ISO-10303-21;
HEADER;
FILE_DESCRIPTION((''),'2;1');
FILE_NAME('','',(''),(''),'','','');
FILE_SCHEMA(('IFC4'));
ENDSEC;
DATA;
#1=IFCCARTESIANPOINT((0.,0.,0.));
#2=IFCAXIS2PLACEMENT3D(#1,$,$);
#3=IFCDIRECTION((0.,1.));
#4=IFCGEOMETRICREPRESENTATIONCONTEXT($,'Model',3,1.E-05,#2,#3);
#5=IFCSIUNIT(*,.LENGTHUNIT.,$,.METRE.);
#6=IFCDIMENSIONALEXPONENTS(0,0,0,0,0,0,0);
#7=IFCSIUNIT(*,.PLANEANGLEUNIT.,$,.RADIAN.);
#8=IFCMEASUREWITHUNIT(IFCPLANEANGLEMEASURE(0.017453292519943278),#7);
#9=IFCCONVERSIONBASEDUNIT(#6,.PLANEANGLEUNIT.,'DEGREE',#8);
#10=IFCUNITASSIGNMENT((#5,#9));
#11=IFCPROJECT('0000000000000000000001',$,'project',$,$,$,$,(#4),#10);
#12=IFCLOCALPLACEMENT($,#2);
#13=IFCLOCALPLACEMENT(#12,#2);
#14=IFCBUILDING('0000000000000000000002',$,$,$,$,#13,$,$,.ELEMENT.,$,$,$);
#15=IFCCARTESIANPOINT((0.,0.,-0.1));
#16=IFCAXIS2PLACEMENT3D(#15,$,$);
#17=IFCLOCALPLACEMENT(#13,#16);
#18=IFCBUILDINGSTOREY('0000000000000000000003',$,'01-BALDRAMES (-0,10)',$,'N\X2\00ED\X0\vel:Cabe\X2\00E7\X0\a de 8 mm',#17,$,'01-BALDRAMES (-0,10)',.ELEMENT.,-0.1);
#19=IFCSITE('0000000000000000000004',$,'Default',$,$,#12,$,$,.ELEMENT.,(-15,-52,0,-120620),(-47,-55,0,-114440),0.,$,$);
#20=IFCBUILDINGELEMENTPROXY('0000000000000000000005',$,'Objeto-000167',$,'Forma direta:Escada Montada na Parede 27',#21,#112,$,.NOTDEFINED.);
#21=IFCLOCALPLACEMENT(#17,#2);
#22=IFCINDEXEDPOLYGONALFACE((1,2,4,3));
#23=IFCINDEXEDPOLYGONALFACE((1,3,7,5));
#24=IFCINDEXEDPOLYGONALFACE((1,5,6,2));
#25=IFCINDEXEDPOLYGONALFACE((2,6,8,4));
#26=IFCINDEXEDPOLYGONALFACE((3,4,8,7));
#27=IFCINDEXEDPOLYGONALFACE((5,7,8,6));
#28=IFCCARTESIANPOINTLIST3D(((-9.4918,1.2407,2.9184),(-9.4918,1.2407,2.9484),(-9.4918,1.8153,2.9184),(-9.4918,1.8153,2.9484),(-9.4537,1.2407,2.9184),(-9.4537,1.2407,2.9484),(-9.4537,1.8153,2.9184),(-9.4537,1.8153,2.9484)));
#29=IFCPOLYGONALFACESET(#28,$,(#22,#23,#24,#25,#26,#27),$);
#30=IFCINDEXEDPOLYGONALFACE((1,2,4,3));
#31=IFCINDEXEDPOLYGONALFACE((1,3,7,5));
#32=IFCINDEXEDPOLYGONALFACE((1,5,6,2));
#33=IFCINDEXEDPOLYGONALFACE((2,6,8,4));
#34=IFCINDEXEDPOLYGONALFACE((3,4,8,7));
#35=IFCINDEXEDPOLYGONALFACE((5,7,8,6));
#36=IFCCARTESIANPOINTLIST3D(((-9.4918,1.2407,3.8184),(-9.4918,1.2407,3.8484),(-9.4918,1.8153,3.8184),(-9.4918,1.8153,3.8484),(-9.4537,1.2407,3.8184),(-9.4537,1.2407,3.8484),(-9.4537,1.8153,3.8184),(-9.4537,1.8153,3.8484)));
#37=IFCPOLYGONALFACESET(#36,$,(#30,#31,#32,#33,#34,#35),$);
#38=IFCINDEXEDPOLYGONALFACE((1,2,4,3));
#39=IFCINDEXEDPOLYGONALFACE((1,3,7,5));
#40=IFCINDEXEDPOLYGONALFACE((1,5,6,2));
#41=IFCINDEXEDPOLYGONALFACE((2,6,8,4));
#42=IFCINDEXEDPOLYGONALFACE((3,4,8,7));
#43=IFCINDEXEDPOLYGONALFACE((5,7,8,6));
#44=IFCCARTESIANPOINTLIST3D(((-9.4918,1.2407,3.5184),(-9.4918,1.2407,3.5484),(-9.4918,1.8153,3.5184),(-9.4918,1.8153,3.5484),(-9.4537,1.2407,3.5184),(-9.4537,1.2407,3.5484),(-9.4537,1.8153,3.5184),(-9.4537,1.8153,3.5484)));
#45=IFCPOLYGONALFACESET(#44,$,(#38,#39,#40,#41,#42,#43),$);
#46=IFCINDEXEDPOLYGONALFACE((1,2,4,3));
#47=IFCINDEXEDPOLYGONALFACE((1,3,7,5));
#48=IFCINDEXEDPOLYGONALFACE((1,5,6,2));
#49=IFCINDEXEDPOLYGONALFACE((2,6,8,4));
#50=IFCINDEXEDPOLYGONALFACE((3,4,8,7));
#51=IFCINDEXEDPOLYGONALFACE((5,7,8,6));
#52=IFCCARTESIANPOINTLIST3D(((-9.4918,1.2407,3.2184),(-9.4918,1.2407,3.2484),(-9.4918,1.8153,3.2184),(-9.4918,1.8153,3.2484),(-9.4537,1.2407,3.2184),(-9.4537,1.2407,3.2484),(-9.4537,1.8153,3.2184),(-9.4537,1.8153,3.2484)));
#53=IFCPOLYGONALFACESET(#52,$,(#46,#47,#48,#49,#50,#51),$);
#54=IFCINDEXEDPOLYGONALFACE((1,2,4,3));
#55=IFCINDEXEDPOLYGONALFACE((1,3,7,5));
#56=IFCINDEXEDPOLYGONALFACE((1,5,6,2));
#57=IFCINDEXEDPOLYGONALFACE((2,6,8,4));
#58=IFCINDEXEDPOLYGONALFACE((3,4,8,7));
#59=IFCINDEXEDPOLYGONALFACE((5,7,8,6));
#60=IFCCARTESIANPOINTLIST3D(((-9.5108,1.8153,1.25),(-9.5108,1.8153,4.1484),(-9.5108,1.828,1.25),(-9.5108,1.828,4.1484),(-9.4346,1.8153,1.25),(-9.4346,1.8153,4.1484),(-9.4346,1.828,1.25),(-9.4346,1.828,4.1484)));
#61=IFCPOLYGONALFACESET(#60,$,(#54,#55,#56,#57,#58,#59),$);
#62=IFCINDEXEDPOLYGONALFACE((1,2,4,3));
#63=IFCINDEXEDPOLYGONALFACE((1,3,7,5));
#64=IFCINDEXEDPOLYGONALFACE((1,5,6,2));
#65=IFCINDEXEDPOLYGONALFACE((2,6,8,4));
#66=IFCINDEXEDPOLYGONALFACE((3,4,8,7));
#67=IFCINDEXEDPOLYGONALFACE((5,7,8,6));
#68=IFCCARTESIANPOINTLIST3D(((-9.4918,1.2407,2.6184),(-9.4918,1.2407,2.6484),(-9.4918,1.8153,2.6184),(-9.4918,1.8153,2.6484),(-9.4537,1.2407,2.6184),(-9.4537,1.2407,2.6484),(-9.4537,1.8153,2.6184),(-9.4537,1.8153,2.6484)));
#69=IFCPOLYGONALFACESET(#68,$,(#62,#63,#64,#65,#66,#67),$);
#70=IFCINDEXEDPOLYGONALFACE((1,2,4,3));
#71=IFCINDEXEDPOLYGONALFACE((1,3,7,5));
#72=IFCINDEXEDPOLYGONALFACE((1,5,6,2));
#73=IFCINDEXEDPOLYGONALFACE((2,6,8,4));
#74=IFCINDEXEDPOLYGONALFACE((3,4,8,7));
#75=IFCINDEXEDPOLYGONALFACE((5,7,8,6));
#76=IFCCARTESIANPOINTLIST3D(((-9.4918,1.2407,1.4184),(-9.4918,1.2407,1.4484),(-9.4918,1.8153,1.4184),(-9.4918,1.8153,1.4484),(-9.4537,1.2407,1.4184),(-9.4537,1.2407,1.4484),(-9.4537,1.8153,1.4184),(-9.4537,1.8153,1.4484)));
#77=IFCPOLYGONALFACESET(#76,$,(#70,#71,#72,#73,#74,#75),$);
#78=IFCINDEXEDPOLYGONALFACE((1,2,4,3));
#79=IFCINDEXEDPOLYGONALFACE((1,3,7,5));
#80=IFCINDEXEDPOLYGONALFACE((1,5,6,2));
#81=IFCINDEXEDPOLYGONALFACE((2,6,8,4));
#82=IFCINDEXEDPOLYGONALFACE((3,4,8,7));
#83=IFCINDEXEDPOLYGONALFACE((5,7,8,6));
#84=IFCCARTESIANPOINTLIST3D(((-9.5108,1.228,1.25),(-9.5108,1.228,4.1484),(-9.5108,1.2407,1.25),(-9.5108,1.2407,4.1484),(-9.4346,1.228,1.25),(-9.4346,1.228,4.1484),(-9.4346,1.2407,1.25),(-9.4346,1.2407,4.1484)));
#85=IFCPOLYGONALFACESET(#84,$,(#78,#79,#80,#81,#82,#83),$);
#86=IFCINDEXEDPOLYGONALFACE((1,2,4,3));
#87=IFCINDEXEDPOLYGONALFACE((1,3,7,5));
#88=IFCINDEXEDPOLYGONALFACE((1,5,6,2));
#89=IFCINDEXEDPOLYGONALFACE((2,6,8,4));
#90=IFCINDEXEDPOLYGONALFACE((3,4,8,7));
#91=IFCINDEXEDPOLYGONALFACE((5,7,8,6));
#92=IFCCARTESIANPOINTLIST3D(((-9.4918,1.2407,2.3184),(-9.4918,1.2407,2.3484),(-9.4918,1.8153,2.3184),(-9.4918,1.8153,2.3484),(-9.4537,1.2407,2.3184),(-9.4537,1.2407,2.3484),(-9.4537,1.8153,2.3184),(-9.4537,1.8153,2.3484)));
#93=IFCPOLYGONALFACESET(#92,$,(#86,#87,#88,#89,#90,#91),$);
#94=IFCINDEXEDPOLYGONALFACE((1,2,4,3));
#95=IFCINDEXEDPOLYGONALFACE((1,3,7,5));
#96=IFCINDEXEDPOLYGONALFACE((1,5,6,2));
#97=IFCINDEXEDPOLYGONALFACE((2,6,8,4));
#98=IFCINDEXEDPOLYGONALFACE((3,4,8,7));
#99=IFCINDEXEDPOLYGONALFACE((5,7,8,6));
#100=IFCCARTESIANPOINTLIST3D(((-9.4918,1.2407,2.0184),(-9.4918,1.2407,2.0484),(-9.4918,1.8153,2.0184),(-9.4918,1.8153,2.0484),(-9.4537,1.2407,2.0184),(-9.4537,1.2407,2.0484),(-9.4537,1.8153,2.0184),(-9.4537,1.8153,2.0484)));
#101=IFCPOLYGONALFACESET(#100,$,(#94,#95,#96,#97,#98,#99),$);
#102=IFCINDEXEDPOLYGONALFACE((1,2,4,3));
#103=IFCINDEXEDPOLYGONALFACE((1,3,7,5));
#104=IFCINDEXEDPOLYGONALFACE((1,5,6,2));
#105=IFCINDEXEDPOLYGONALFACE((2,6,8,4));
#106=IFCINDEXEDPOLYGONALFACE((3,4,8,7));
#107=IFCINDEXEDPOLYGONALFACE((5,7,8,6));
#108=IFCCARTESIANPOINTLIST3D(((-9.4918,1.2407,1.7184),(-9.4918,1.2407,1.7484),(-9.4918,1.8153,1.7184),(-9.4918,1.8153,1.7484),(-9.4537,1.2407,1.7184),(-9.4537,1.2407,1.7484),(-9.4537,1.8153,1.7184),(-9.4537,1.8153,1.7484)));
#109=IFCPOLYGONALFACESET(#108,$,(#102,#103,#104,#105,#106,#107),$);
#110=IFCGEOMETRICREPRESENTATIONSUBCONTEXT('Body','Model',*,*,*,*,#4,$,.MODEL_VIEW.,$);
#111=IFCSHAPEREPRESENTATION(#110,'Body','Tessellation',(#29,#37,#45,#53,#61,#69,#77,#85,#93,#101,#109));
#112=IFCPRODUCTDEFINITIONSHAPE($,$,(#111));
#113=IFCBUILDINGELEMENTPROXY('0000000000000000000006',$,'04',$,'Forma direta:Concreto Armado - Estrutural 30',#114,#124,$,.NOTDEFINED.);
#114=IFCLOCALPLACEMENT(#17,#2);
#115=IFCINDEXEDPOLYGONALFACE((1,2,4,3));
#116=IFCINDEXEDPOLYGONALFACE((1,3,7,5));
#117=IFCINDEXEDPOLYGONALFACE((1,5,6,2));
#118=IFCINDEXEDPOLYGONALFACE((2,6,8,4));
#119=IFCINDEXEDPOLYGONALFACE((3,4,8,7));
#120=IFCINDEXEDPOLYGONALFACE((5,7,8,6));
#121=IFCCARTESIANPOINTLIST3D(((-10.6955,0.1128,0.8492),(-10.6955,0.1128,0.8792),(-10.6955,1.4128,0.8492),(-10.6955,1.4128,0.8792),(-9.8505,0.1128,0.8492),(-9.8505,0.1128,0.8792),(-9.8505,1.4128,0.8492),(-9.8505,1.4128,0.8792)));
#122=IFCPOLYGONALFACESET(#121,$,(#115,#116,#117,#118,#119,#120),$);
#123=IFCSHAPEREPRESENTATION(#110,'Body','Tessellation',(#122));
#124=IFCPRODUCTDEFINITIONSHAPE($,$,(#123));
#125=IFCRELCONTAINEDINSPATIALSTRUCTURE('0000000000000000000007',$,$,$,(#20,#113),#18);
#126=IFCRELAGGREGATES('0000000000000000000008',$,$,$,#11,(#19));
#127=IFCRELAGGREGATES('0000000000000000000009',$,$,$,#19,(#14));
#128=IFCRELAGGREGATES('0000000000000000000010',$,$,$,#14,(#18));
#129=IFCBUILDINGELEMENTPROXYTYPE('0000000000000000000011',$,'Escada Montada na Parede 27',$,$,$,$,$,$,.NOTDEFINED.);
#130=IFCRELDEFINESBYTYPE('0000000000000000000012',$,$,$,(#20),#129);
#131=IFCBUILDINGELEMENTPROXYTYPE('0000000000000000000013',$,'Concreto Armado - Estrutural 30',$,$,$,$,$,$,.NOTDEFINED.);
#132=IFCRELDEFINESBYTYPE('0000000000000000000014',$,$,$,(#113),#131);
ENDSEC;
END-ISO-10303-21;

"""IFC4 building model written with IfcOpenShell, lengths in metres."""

from ifc_helpers import new_model, entity, si_unit, converted_unit, direction, frame, origin, place, context, subcontext, project, spatial, indexed_curve, outline, extrude, type_object, element, save


model = new_model("IFC4")

# Units and contexts
model_context = context("Model", 3, precision=1e-05, world=origin(), true_north=direction((0.0, 1.0)))
body_context = subcontext(model_context, "Body", "Model", "MODEL_VIEW")
ifc_project = project(units=[si_unit("LENGTHUNIT", "METRE"), converted_unit("PLANEANGLEUNIT", "DEGREE", entity("IfcPlaneAngleMeasure", 0.017453292519943278), si_unit("PLANEANGLEUNIT", "RADIAN"), dimensions=[0, 0, 0, 0, 0, 0, 0])], contexts=[model_context])

# Site, building, storey
site_placement = place(None, origin())
site = spatial("IfcSite", under=ifc_project, at=site_placement, Name="Default", CompositionType="ELEMENT", RefLatitude=(-15, -52, 0, -120620), RefLongitude=(-47, -55, 0, -114440), RefElevation=0.0)
building_placement = place(site_placement, origin())
building = spatial("IfcBuilding", under=site, at=building_placement, CompositionType="ELEMENT")
storey_placement = place(building_placement, frame((0.0, 0.0, -0.1)))
storey = spatial("IfcBuildingStorey", under=building, at=storey_placement, Name="01-BALDRAMES (-0,10)", ObjectType="Nível:Cabeça de 8 mm", LongName="01-BALDRAMES (-0,10)", CompositionType="ELEMENT", Elevation=-0.1)

# Building element proxies
building_element_proxy_type_1 = type_object("IfcBuildingElementProxyType", Name="Escada Montada na Parede 27", PredefinedType="NOTDEFINED")
proxy_1_placement = place(storey_placement, origin())
element("IfcBuildingElementProxy", 1, at=proxy_1_placement, inside=storey, type_object=building_element_proxy_type_1, Name="Objeto-000167", ObjectType="Forma direta:Escada Montada na Parede 27", PredefinedType="NOTDEFINED", context=body_context, shape_type="SweptSolid", body=[
    extrude(outline(indexed_curve([(-0.0191, -0.2873), (0.019, -0.2873), (0.0191, 0.2873), (-0.019, 0.2873), (-0.0191, -0.2873)], self_intersect=False)), frame((-9.4727, 1.528, 2.9184), z_axis=(0.0, 0.0, 1.0), x_axis=(-1.0, -0.000006, 0.0)), (0.0, 0.0, 1.0), 0.03),
    extrude(outline(indexed_curve([(-0.0191, -0.2873), (0.019, -0.2873), (0.0191, 0.2873), (-0.019, 0.2873), (-0.0191, -0.2873)], self_intersect=False)), frame((-9.4727, 1.528, 3.8184), z_axis=(0.0, 0.0, 1.0), x_axis=(-1.0, -0.000006, 0.0)), (0.0, 0.0, 1.0), 0.03),
    extrude(outline(indexed_curve([(-0.0191, -0.2873), (0.019, -0.2873), (0.0191, 0.2873), (-0.019, 0.2873), (-0.0191, -0.2873)], self_intersect=False)), frame((-9.4727, 1.528, 3.5184), z_axis=(0.0, 0.0, 1.0), x_axis=(-1.0, -0.000006, 0.0)), (0.0, 0.0, 1.0), 0.03),
    extrude(outline(indexed_curve([(-0.0191, -0.2873), (0.019, -0.2873), (0.0191, 0.2873), (-0.019, 0.2873), (-0.0191, -0.2873)], self_intersect=False)), frame((-9.4727, 1.528, 3.2184), z_axis=(0.0, 0.0, 1.0), x_axis=(-1.0, -0.000006, 0.0)), (0.0, 0.0, 1.0), 0.03),
    extrude(outline(indexed_curve([(-0.0064, -0.0381), (0.0063, -0.0381), (0.0064, 0.0381), (-0.0063, 0.0381), (-0.0064, -0.0381)], self_intersect=False)), frame((-9.4727, 1.8217, 1.25), z_axis=(0.0, 0.0, 1.0), x_axis=(0.000006, -1.0, 0.0)), (0.0, 0.0, 1.0), 2.8984),
    extrude(outline(indexed_curve([(-0.0191, -0.2873), (0.019, -0.2873), (0.0191, 0.2873), (-0.019, 0.2873), (-0.0191, -0.2873)], self_intersect=False)), frame((-9.4727, 1.528, 2.6184), z_axis=(0.0, 0.0, 1.0), x_axis=(-1.0, -0.000006, 0.0)), (0.0, 0.0, 1.0), 0.03),
    extrude(outline(indexed_curve([(-0.0191, -0.2873), (0.019, -0.2873), (0.0191, 0.2873), (-0.019, 0.2873), (-0.0191, -0.2873)], self_intersect=False)), frame((-9.4727, 1.528, 1.4184), z_axis=(0.0, 0.0, 1.0), x_axis=(-1.0, -0.000006, 0.0)), (0.0, 0.0, 1.0), 0.03),
    extrude(outline(indexed_curve([(-0.0064, -0.0381), (0.0063, -0.0381), (0.0064, 0.0381), (-0.0063, 0.0381), (-0.0064, -0.0381)], self_intersect=False)), frame((-9.4727, 1.2344, 1.25), z_axis=(0.0, 0.0, 1.0), x_axis=(-0.000006, 1.0, 0.0)), (0.0, 0.0, 1.0), 2.8984),
    extrude(outline(indexed_curve([(-0.0191, -0.2873), (0.019, -0.2873), (0.0191, 0.2873), (-0.019, 0.2873), (-0.0191, -0.2873)], self_intersect=False)), frame((-9.4727, 1.528, 2.3184), z_axis=(0.0, 0.0, 1.0), x_axis=(-1.0, -0.000006, 0.0)), (0.0, 0.0, 1.0), 0.03),
    extrude(outline(indexed_curve([(-0.0191, -0.2873), (0.019, -0.2873), (0.0191, 0.2873), (-0.019, 0.2873), (-0.0191, -0.2873)], self_intersect=False)), frame((-9.4727, 1.528, 2.0184), z_axis=(0.0, 0.0, 1.0), x_axis=(-1.0, -0.000006, 0.0)), (0.0, 0.0, 1.0), 0.03),
    extrude(outline(indexed_curve([(-0.0191, -0.2873), (0.019, -0.2873), (0.0191, 0.2873), (-0.019, 0.2873), (-0.0191, -0.2873)], self_intersect=False)), frame((-9.4727, 1.528, 1.7184), z_axis=(0.0, 0.0, 1.0), x_axis=(-1.0, -0.000006, 0.0)), (0.0, 0.0, 1.0), 0.03),
])
building_element_proxy_type_2 = type_object("IfcBuildingElementProxyType", Name="Concreto Armado - Estrutural 30", PredefinedType="NOTDEFINED")
proxy_2_placement = place(storey_placement, origin())
element("IfcBuildingElementProxy", 2, at=proxy_2_placement, inside=storey, type_object=building_element_proxy_type_2, Name="04", ObjectType="Forma direta:Concreto Armado - Estrutural 30", PredefinedType="NOTDEFINED", context=body_context, shape_type="SweptSolid", body=[
    extrude(outline(indexed_curve([(-0.65, -0.4225), (0.65, -0.4225), (0.65, 0.4225), (-0.65, 0.4225), (-0.65, -0.4225)], self_intersect=False)), frame((-10.273, 0.7628, 0.8492), z_axis=(0.0, 0.0, 1.0), x_axis=(0.000013, 1.0, 0.0)), (0.0, 0.0, 1.0), 0.03),
])

save(model, "model.ifc")
